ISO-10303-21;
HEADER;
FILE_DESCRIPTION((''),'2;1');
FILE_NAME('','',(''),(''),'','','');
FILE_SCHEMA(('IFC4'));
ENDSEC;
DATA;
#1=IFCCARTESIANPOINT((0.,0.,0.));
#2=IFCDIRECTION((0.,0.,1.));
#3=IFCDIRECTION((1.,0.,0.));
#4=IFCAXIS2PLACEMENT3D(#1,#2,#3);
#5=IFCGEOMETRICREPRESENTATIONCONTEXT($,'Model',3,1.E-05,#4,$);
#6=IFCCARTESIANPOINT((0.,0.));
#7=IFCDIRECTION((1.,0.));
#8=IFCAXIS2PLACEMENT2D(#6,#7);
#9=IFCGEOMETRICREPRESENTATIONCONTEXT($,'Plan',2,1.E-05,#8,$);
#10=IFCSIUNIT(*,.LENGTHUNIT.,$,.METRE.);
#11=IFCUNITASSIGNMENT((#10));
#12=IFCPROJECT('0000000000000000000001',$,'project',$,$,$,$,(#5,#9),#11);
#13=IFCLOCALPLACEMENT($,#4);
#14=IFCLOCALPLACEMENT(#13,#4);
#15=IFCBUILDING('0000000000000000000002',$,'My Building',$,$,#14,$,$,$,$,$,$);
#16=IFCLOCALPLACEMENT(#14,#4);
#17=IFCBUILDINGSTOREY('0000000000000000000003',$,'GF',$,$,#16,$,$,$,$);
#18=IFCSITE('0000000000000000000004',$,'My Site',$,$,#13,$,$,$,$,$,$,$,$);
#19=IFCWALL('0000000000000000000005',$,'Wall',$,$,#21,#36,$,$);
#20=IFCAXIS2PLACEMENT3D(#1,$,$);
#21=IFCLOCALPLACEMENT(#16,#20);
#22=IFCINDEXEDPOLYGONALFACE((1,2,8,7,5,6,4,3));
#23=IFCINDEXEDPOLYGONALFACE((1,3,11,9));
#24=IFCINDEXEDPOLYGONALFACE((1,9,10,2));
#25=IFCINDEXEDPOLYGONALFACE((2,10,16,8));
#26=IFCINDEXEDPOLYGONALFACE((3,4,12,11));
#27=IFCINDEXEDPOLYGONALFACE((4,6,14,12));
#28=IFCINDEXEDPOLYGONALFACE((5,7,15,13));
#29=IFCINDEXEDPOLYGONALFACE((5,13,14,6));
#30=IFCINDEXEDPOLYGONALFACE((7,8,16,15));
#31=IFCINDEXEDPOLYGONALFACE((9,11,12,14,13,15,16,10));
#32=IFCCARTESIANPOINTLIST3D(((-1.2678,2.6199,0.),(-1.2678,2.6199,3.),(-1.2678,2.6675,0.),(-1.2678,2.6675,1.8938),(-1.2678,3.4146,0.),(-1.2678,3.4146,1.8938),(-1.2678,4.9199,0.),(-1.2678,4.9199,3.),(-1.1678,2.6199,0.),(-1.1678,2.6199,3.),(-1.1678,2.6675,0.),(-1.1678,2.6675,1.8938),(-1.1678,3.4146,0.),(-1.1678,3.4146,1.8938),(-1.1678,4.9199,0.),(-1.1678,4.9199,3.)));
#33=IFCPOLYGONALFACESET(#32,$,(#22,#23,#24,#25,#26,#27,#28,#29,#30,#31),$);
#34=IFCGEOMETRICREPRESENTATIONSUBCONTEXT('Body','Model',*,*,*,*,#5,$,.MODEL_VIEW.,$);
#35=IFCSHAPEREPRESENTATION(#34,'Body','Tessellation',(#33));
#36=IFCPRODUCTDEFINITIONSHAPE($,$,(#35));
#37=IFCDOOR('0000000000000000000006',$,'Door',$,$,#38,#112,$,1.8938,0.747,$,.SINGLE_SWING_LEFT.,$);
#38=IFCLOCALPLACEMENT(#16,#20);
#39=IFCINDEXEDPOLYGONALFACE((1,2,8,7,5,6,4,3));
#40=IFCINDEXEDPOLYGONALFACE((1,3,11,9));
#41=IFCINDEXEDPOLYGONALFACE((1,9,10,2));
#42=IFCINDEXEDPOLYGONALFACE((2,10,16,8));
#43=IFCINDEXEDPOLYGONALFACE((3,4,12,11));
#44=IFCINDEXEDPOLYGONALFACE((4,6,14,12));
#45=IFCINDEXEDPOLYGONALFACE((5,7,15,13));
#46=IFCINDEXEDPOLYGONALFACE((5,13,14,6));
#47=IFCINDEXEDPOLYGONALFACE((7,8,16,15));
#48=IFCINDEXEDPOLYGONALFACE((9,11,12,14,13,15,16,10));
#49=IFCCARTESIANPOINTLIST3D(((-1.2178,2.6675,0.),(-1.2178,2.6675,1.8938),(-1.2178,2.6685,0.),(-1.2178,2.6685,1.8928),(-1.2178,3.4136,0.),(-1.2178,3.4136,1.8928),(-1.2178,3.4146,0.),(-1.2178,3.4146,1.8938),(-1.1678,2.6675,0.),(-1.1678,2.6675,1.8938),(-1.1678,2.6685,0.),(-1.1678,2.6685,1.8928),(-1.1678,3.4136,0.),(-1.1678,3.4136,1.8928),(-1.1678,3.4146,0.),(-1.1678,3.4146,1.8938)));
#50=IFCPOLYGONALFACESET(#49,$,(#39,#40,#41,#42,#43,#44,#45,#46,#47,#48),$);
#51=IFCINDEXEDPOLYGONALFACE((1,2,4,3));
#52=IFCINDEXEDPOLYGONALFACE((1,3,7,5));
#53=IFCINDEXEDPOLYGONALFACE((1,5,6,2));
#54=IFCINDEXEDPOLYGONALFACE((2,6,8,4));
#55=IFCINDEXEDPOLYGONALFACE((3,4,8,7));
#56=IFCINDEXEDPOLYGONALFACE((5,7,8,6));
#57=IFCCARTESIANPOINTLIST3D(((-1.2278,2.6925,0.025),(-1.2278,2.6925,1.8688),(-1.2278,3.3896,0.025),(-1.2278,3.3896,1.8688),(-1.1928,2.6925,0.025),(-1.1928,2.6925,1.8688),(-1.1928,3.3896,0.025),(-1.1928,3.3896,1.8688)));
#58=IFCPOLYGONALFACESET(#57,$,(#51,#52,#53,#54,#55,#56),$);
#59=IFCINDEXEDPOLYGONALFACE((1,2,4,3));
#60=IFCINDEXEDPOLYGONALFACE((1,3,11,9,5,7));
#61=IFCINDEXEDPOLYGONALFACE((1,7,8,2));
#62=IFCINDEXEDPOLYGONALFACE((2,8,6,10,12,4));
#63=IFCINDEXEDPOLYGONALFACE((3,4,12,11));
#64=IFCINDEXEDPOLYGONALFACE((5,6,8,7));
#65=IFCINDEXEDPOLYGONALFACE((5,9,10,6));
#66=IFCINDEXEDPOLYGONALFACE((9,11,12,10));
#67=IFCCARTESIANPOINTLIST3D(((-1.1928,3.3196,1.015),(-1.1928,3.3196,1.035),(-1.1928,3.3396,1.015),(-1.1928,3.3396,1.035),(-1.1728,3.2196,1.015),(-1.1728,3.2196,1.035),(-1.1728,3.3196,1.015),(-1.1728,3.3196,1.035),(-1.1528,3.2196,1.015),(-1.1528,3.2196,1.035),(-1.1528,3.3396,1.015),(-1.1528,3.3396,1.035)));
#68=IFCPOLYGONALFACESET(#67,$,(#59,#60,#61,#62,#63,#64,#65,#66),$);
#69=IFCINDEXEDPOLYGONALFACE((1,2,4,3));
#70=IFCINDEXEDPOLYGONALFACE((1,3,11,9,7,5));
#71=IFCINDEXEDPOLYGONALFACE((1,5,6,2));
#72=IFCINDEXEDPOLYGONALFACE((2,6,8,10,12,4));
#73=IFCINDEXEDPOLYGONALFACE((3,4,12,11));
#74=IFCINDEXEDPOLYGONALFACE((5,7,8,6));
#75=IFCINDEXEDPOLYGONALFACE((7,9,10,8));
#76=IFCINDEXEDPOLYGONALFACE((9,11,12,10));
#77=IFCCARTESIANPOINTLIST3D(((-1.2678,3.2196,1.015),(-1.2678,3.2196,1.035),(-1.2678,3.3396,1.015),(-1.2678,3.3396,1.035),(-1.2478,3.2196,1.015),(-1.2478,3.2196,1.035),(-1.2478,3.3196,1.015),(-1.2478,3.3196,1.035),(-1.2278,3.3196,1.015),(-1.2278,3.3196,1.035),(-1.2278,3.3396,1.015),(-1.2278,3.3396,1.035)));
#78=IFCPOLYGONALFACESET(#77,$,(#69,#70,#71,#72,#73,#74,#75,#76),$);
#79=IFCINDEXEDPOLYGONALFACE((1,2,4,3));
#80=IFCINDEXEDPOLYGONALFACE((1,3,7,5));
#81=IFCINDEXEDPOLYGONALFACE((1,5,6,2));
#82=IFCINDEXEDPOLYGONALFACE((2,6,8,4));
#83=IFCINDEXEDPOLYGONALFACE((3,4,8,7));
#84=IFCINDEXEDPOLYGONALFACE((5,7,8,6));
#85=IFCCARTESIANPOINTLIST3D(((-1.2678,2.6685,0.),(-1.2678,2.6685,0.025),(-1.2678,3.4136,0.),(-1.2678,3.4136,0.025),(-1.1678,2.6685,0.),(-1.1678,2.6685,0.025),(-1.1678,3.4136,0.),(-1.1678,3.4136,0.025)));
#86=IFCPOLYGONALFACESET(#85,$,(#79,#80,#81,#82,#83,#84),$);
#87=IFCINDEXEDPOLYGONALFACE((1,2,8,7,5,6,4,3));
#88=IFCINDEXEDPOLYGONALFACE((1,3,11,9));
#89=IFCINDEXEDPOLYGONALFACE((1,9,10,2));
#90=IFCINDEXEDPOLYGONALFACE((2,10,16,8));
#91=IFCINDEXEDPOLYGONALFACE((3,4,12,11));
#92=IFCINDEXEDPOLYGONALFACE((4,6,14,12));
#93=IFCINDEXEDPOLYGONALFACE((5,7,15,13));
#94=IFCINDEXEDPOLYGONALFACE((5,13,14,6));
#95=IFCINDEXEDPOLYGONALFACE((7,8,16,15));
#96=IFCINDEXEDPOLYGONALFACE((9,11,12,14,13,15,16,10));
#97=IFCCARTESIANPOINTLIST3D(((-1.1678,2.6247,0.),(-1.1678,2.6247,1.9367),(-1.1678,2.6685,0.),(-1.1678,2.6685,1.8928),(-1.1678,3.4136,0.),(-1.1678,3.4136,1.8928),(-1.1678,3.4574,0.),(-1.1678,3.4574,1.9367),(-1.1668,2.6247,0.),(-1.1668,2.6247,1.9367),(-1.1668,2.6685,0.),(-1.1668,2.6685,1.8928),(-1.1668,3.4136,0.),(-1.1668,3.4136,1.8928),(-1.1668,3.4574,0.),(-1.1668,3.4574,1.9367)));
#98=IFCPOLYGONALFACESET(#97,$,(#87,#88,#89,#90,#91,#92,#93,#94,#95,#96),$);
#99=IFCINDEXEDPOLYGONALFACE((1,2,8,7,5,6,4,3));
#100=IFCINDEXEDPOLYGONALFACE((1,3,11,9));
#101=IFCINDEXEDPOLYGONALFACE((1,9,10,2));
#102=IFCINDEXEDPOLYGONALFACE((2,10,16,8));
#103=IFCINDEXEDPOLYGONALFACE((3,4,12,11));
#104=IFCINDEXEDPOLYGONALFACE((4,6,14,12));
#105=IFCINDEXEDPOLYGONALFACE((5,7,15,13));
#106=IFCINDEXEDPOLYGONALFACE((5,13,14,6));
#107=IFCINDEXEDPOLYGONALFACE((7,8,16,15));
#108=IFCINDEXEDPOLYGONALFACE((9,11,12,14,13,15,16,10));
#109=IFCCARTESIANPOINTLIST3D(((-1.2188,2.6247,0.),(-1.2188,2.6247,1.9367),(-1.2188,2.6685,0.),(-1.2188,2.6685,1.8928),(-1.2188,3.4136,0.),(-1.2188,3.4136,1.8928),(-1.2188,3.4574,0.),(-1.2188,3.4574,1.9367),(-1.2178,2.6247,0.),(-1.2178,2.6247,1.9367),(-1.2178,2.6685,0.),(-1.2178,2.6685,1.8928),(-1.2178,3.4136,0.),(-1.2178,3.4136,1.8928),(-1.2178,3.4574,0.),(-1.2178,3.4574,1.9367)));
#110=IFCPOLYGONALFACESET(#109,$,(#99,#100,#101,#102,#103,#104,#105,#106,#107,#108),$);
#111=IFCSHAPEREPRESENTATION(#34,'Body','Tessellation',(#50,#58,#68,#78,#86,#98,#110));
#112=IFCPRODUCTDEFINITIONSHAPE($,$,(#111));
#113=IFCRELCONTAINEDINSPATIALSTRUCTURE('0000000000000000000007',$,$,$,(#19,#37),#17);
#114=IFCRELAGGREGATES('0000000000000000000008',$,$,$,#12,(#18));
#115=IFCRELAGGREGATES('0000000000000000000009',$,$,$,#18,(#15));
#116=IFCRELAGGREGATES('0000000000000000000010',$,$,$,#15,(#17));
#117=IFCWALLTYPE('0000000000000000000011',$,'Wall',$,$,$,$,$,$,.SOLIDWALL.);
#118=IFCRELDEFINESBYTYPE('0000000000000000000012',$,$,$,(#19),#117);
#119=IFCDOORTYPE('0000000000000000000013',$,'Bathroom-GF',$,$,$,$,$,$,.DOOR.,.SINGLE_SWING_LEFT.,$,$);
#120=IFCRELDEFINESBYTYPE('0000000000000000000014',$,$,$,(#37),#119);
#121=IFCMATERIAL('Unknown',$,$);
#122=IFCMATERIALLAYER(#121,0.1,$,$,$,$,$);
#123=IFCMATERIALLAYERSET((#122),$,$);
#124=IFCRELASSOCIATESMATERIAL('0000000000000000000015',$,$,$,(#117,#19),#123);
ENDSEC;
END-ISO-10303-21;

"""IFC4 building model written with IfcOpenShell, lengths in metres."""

from ifc_helpers import new_model, entity, si_unit, frame, origin_with_axes, origin_2d_with_axis, place, context, subcontext, project, spatial, line, indexed_curve, outline, extrude, shape, source, transform, mapped, material, layer, layer_set, layer_usage, type_object, type_shapes, element, fill, save


model = new_model("IFC4")

# Units and contexts
model_context = context("Model", 3, precision=1e-05, world=origin_with_axes())
plan_context = context("Plan", 2, precision=1e-05, world=origin_2d_with_axis())
body_context_1 = subcontext(model_context, "Body", "Model", "MODEL_VIEW")
body_context_2 = subcontext(plan_context, "Body", "Plan", "PLAN_VIEW")
ifc_project = project(units=[si_unit("LENGTHUNIT", "METRE")], contexts=[model_context, plan_context])

# Site, building, storey
site_placement = place(None, origin_with_axes())
site = spatial("IfcSite", under=ifc_project, at=site_placement, Name="My Site")
building_placement = place(site_placement, origin_with_axes())
building = spatial("IfcBuilding", under=site, at=building_placement, Name="My Building")
storey_placement = place(building_placement, origin_with_axes())
storey = spatial("IfcBuildingStorey", under=building, at=storey_placement, Name="GF")

# Shared definitions
ifc_material = material(Name="Unknown")

# Shared definitions
ifc_layer_1 = layer(ifc_material, 0.1)
ifc_layer_set_1 = layer_set([ifc_layer_1])
wall_type = type_object("IfcWallType", Name="Wall", PredefinedType="SOLIDWALL", material=ifc_layer_set_1)

# Wall, opening, door
ifc_layer_usage_1 = layer_usage(ifc_layer_set_1, "AXIS2", "POSITIVE", 0.0)
wall_1_placement = place(storey_placement, frame((-1.1678, 2.6199, 0.0), z_axis=(0.0, 0.0, 1.0), x_axis=(0.0, 1.0, 0.0)))
wall_1 = element("IfcWall", 1, at=wall_1_placement, inside=storey, type_object=wall_type, material=ifc_layer_usage_1, Name="Wall", context=body_context_1, shape_type="SweptSolid", body=[
    extrude(outline(indexed_curve([(0.0, 0.0), (0.0, 0.1), (2.3, 0.1), (2.3, 0.0)], segments=[line(1, 2, 3, 4, 1)])), origin_with_axes(), (0.0, 0.0, 1.0), 3.0),
])
shared_shape_1 = source(origin_with_axes(), body_context_1, "Body", "SweptSolid", [
    extrude(outline(indexed_curve([(0.0, 0.0), (0.747, 0.0), (0.747, 1.8938), (0.0, 1.8938)], segments=[line(1, 2, 3, 4, 1)])), frame((0.0, -0.6, 0.0), z_axis=(0.0, -1.0, 0.0), x_axis=(1.0, 0.0, 0.0)), (0.0, 0.0, -1.0), 1.2),
])
opening_1_placement = place(wall_1_placement, frame((0.0477, 0.0, 0.0), z_axis=(0.0, 0.0, 1.0), x_axis=(1.0, 0.0, 0.0)))
opening_1 = element("IfcOpeningElement", 2, at=opening_1_placement, cuts=wall_1, PredefinedType="OPENING", context=body_context_1, shape_type="MappedRepresentation", body=[
    mapped(shared_shape_1, transform((0.0, 0.0, 0.0), x_axis=(1.0, 0.0, 0.0), y_axis=(0.0, 1.0, 0.0), z_axis=(0.0, 0.0, 1.0), scale=1.0)),
])
door_type_1 = type_object("IfcDoorType", Name="Bathroom-GF", OperationType="SINGLE_SWING_LEFT", PredefinedType="DOOR")
shared_shape_2 = source(origin_with_axes(), body_context_1, "Body", "SweptSolid", [
    extrude(outline(indexed_curve([(0.0, 0.0), (0.0, 1.8938), (0.747, 1.8938), (0.747, 0.0), (0.746, 0.0), (0.746, 1.8928), (0.001, 1.8928), (0.001, 0.0)], segments=[line(1, 2, 3, 4, 5, 6, 7, 8, 1)])), frame((0.0, 0.0, 0.0), z_axis=(0.0, -1.0, 0.0), x_axis=(1.0, 0.0, 0.0)), (0.0, 0.0, -1.0), 0.05),
    extrude(outline(indexed_curve([(0.0, 0.0), (0.697, 0.0), (0.697, 0.035), (0.0, 0.035)], segments=[line(1, 2, 3, 4, 1)])), frame((0.025, 0.025, 0.025), z_axis=(0.0, 0.0, 1.0), x_axis=(1.0, 0.0, 0.0)), (0.0, 0.0, 1.0), 1.8438),
    extrude(outline(indexed_curve([(0.0, 0.0), (0.0, -0.04), (-0.12, -0.04), (-0.12, -0.02), (-0.02, -0.02), (-0.02, 0.0)], segments=[line(1, 2, 3, 4, 5, 6, 1)])), frame((0.672, 0.025, 1.015), z_axis=(0.0, 0.0, 1.0), x_axis=(1.0, 0.0, 0.0)), (0.0, 0.0, 1.0), 0.02),
    extrude(outline(indexed_curve([(0.0, 0.0), (0.0, 0.04), (-0.12, 0.04), (-0.12, 0.02), (-0.02, 0.02), (-0.02, 0.0)], segments=[line(1, 2, 3, 4, 5, 6, 1)])), frame((0.672, 0.06, 1.015), z_axis=(0.0, 0.0, 1.0), x_axis=(1.0, 0.0, 0.0)), (0.0, 0.0, 1.0), 0.02),
    extrude(outline(indexed_curve([(0.0, 0.0), (0.745, 0.0), (0.745, 0.1), (0.0, 0.1)], segments=[line(1, 2, 3, 4, 1)])), frame((0.001, 0.0, 0.0), z_axis=(0.0, 0.0, 1.0), x_axis=(1.0, 0.0, 0.0)), (0.0, 0.0, 1.0), 0.025),
    extrude(outline(indexed_curve([(0.0, 0.0), (0.0, 1.9367), (0.8327, 1.9367), (0.8327, 0.0), (0.7889, 0.0), (0.7889, 1.8928), (0.0439, 1.8928), (0.0439, 0.0)], segments=[line(1, 2, 3, 4, 5, 6, 7, 8, 1)])), frame((-0.0429, -0.001, 0.0), z_axis=(0.0, -1.0, 0.0), x_axis=(1.0, 0.0, 0.0)), (0.0, 0.0, -1.0), 0.001),
    extrude(outline(indexed_curve([(0.0, 0.0), (0.0, 1.9367), (0.8327, 1.9367), (0.8327, 0.0), (0.7889, 0.0), (0.7889, 1.8928), (0.0439, 1.8928), (0.0439, 0.0)], segments=[line(1, 2, 3, 4, 5, 6, 7, 8, 1)])), frame((-0.0429, 0.05, 0.0), z_axis=(0.0, -1.0, 0.0), x_axis=(1.0, 0.0, 0.0)), (0.0, 0.0, -1.0), 0.001),
])
shared_shape_3 = source(origin_with_axes(), body_context_2, "Body", "Curve2D", [
    entity("IfcIndexedPolyCurve", entity("IfcCartesianPointList2D", [[0.0, 0.0], [0.001, 0.0], [0.001, 0.05], [0.0, 0.05]]), [entity("IfcLineIndex", [1, 2, 3, 4, 1])]),
    entity("IfcIndexedPolyCurve", entity("IfcCartesianPointList2D", [[0.747, 0.0], [0.746, 0.0], [0.746, 0.05], [0.747, 0.05]]), [entity("IfcLineIndex", [1, 2, 3, 4, 1])]),
    entity("IfcTrimmedCurve", entity("IfcEllipse", entity("IfcAxis2Placement2D", entity("IfcCartesianPoint", [0.06, 0.05]), entity("IfcDirection", [1.0, 0.0])), 0.662, 0.697), [entity("IfcCartesianPoint", [0.722, 0.05])], [entity("IfcCartesianPoint", [0.06, 0.747])], True, "CARTESIAN"),
    entity("IfcIndexedPolyCurve", entity("IfcCartesianPointList2D", [[0.025, 0.05], [0.06, 0.05], [0.06, 0.747], [0.025, 0.747]]), [entity("IfcLineIndex", [1, 2, 3, 4, 1])]),
])
type_shapes(door_type_1, [shared_shape_2, shared_shape_3])
door_1_placement = place(opening_1_placement, frame((0.0, 0.0, 0.0), z_axis=(0.0, 0.0, 1.0), x_axis=(1.0, 0.0, 0.0)))
door_1 = element("IfcDoor", 3, at=door_1_placement, inside=storey, type_object=door_type_1, Name="Door", OperationType="SINGLE_SWING_LEFT", OverallHeight=1.8938, OverallWidth=0.747, shapes=[
    shape(body_context_1, "Body", "MappedRepresentation", [mapped(shared_shape_2, transform((0.0, 0.0, 0.0), x_axis=(1.0, 0.0, 0.0), y_axis=(0.0, 1.0, 0.0), z_axis=(0.0, 0.0, 1.0), scale=1.0))]),
    shape(body_context_2, "Body", "MappedRepresentation", [mapped(shared_shape_3, transform((0.0, 0.0, 0.0), x_axis=(1.0, 0.0, 0.0), y_axis=(0.0, 1.0, 0.0), z_axis=(0.0, 0.0, 1.0), scale=1.0))]),
])
fill(opening_1, door_1)

save(model, "model.ifc")
